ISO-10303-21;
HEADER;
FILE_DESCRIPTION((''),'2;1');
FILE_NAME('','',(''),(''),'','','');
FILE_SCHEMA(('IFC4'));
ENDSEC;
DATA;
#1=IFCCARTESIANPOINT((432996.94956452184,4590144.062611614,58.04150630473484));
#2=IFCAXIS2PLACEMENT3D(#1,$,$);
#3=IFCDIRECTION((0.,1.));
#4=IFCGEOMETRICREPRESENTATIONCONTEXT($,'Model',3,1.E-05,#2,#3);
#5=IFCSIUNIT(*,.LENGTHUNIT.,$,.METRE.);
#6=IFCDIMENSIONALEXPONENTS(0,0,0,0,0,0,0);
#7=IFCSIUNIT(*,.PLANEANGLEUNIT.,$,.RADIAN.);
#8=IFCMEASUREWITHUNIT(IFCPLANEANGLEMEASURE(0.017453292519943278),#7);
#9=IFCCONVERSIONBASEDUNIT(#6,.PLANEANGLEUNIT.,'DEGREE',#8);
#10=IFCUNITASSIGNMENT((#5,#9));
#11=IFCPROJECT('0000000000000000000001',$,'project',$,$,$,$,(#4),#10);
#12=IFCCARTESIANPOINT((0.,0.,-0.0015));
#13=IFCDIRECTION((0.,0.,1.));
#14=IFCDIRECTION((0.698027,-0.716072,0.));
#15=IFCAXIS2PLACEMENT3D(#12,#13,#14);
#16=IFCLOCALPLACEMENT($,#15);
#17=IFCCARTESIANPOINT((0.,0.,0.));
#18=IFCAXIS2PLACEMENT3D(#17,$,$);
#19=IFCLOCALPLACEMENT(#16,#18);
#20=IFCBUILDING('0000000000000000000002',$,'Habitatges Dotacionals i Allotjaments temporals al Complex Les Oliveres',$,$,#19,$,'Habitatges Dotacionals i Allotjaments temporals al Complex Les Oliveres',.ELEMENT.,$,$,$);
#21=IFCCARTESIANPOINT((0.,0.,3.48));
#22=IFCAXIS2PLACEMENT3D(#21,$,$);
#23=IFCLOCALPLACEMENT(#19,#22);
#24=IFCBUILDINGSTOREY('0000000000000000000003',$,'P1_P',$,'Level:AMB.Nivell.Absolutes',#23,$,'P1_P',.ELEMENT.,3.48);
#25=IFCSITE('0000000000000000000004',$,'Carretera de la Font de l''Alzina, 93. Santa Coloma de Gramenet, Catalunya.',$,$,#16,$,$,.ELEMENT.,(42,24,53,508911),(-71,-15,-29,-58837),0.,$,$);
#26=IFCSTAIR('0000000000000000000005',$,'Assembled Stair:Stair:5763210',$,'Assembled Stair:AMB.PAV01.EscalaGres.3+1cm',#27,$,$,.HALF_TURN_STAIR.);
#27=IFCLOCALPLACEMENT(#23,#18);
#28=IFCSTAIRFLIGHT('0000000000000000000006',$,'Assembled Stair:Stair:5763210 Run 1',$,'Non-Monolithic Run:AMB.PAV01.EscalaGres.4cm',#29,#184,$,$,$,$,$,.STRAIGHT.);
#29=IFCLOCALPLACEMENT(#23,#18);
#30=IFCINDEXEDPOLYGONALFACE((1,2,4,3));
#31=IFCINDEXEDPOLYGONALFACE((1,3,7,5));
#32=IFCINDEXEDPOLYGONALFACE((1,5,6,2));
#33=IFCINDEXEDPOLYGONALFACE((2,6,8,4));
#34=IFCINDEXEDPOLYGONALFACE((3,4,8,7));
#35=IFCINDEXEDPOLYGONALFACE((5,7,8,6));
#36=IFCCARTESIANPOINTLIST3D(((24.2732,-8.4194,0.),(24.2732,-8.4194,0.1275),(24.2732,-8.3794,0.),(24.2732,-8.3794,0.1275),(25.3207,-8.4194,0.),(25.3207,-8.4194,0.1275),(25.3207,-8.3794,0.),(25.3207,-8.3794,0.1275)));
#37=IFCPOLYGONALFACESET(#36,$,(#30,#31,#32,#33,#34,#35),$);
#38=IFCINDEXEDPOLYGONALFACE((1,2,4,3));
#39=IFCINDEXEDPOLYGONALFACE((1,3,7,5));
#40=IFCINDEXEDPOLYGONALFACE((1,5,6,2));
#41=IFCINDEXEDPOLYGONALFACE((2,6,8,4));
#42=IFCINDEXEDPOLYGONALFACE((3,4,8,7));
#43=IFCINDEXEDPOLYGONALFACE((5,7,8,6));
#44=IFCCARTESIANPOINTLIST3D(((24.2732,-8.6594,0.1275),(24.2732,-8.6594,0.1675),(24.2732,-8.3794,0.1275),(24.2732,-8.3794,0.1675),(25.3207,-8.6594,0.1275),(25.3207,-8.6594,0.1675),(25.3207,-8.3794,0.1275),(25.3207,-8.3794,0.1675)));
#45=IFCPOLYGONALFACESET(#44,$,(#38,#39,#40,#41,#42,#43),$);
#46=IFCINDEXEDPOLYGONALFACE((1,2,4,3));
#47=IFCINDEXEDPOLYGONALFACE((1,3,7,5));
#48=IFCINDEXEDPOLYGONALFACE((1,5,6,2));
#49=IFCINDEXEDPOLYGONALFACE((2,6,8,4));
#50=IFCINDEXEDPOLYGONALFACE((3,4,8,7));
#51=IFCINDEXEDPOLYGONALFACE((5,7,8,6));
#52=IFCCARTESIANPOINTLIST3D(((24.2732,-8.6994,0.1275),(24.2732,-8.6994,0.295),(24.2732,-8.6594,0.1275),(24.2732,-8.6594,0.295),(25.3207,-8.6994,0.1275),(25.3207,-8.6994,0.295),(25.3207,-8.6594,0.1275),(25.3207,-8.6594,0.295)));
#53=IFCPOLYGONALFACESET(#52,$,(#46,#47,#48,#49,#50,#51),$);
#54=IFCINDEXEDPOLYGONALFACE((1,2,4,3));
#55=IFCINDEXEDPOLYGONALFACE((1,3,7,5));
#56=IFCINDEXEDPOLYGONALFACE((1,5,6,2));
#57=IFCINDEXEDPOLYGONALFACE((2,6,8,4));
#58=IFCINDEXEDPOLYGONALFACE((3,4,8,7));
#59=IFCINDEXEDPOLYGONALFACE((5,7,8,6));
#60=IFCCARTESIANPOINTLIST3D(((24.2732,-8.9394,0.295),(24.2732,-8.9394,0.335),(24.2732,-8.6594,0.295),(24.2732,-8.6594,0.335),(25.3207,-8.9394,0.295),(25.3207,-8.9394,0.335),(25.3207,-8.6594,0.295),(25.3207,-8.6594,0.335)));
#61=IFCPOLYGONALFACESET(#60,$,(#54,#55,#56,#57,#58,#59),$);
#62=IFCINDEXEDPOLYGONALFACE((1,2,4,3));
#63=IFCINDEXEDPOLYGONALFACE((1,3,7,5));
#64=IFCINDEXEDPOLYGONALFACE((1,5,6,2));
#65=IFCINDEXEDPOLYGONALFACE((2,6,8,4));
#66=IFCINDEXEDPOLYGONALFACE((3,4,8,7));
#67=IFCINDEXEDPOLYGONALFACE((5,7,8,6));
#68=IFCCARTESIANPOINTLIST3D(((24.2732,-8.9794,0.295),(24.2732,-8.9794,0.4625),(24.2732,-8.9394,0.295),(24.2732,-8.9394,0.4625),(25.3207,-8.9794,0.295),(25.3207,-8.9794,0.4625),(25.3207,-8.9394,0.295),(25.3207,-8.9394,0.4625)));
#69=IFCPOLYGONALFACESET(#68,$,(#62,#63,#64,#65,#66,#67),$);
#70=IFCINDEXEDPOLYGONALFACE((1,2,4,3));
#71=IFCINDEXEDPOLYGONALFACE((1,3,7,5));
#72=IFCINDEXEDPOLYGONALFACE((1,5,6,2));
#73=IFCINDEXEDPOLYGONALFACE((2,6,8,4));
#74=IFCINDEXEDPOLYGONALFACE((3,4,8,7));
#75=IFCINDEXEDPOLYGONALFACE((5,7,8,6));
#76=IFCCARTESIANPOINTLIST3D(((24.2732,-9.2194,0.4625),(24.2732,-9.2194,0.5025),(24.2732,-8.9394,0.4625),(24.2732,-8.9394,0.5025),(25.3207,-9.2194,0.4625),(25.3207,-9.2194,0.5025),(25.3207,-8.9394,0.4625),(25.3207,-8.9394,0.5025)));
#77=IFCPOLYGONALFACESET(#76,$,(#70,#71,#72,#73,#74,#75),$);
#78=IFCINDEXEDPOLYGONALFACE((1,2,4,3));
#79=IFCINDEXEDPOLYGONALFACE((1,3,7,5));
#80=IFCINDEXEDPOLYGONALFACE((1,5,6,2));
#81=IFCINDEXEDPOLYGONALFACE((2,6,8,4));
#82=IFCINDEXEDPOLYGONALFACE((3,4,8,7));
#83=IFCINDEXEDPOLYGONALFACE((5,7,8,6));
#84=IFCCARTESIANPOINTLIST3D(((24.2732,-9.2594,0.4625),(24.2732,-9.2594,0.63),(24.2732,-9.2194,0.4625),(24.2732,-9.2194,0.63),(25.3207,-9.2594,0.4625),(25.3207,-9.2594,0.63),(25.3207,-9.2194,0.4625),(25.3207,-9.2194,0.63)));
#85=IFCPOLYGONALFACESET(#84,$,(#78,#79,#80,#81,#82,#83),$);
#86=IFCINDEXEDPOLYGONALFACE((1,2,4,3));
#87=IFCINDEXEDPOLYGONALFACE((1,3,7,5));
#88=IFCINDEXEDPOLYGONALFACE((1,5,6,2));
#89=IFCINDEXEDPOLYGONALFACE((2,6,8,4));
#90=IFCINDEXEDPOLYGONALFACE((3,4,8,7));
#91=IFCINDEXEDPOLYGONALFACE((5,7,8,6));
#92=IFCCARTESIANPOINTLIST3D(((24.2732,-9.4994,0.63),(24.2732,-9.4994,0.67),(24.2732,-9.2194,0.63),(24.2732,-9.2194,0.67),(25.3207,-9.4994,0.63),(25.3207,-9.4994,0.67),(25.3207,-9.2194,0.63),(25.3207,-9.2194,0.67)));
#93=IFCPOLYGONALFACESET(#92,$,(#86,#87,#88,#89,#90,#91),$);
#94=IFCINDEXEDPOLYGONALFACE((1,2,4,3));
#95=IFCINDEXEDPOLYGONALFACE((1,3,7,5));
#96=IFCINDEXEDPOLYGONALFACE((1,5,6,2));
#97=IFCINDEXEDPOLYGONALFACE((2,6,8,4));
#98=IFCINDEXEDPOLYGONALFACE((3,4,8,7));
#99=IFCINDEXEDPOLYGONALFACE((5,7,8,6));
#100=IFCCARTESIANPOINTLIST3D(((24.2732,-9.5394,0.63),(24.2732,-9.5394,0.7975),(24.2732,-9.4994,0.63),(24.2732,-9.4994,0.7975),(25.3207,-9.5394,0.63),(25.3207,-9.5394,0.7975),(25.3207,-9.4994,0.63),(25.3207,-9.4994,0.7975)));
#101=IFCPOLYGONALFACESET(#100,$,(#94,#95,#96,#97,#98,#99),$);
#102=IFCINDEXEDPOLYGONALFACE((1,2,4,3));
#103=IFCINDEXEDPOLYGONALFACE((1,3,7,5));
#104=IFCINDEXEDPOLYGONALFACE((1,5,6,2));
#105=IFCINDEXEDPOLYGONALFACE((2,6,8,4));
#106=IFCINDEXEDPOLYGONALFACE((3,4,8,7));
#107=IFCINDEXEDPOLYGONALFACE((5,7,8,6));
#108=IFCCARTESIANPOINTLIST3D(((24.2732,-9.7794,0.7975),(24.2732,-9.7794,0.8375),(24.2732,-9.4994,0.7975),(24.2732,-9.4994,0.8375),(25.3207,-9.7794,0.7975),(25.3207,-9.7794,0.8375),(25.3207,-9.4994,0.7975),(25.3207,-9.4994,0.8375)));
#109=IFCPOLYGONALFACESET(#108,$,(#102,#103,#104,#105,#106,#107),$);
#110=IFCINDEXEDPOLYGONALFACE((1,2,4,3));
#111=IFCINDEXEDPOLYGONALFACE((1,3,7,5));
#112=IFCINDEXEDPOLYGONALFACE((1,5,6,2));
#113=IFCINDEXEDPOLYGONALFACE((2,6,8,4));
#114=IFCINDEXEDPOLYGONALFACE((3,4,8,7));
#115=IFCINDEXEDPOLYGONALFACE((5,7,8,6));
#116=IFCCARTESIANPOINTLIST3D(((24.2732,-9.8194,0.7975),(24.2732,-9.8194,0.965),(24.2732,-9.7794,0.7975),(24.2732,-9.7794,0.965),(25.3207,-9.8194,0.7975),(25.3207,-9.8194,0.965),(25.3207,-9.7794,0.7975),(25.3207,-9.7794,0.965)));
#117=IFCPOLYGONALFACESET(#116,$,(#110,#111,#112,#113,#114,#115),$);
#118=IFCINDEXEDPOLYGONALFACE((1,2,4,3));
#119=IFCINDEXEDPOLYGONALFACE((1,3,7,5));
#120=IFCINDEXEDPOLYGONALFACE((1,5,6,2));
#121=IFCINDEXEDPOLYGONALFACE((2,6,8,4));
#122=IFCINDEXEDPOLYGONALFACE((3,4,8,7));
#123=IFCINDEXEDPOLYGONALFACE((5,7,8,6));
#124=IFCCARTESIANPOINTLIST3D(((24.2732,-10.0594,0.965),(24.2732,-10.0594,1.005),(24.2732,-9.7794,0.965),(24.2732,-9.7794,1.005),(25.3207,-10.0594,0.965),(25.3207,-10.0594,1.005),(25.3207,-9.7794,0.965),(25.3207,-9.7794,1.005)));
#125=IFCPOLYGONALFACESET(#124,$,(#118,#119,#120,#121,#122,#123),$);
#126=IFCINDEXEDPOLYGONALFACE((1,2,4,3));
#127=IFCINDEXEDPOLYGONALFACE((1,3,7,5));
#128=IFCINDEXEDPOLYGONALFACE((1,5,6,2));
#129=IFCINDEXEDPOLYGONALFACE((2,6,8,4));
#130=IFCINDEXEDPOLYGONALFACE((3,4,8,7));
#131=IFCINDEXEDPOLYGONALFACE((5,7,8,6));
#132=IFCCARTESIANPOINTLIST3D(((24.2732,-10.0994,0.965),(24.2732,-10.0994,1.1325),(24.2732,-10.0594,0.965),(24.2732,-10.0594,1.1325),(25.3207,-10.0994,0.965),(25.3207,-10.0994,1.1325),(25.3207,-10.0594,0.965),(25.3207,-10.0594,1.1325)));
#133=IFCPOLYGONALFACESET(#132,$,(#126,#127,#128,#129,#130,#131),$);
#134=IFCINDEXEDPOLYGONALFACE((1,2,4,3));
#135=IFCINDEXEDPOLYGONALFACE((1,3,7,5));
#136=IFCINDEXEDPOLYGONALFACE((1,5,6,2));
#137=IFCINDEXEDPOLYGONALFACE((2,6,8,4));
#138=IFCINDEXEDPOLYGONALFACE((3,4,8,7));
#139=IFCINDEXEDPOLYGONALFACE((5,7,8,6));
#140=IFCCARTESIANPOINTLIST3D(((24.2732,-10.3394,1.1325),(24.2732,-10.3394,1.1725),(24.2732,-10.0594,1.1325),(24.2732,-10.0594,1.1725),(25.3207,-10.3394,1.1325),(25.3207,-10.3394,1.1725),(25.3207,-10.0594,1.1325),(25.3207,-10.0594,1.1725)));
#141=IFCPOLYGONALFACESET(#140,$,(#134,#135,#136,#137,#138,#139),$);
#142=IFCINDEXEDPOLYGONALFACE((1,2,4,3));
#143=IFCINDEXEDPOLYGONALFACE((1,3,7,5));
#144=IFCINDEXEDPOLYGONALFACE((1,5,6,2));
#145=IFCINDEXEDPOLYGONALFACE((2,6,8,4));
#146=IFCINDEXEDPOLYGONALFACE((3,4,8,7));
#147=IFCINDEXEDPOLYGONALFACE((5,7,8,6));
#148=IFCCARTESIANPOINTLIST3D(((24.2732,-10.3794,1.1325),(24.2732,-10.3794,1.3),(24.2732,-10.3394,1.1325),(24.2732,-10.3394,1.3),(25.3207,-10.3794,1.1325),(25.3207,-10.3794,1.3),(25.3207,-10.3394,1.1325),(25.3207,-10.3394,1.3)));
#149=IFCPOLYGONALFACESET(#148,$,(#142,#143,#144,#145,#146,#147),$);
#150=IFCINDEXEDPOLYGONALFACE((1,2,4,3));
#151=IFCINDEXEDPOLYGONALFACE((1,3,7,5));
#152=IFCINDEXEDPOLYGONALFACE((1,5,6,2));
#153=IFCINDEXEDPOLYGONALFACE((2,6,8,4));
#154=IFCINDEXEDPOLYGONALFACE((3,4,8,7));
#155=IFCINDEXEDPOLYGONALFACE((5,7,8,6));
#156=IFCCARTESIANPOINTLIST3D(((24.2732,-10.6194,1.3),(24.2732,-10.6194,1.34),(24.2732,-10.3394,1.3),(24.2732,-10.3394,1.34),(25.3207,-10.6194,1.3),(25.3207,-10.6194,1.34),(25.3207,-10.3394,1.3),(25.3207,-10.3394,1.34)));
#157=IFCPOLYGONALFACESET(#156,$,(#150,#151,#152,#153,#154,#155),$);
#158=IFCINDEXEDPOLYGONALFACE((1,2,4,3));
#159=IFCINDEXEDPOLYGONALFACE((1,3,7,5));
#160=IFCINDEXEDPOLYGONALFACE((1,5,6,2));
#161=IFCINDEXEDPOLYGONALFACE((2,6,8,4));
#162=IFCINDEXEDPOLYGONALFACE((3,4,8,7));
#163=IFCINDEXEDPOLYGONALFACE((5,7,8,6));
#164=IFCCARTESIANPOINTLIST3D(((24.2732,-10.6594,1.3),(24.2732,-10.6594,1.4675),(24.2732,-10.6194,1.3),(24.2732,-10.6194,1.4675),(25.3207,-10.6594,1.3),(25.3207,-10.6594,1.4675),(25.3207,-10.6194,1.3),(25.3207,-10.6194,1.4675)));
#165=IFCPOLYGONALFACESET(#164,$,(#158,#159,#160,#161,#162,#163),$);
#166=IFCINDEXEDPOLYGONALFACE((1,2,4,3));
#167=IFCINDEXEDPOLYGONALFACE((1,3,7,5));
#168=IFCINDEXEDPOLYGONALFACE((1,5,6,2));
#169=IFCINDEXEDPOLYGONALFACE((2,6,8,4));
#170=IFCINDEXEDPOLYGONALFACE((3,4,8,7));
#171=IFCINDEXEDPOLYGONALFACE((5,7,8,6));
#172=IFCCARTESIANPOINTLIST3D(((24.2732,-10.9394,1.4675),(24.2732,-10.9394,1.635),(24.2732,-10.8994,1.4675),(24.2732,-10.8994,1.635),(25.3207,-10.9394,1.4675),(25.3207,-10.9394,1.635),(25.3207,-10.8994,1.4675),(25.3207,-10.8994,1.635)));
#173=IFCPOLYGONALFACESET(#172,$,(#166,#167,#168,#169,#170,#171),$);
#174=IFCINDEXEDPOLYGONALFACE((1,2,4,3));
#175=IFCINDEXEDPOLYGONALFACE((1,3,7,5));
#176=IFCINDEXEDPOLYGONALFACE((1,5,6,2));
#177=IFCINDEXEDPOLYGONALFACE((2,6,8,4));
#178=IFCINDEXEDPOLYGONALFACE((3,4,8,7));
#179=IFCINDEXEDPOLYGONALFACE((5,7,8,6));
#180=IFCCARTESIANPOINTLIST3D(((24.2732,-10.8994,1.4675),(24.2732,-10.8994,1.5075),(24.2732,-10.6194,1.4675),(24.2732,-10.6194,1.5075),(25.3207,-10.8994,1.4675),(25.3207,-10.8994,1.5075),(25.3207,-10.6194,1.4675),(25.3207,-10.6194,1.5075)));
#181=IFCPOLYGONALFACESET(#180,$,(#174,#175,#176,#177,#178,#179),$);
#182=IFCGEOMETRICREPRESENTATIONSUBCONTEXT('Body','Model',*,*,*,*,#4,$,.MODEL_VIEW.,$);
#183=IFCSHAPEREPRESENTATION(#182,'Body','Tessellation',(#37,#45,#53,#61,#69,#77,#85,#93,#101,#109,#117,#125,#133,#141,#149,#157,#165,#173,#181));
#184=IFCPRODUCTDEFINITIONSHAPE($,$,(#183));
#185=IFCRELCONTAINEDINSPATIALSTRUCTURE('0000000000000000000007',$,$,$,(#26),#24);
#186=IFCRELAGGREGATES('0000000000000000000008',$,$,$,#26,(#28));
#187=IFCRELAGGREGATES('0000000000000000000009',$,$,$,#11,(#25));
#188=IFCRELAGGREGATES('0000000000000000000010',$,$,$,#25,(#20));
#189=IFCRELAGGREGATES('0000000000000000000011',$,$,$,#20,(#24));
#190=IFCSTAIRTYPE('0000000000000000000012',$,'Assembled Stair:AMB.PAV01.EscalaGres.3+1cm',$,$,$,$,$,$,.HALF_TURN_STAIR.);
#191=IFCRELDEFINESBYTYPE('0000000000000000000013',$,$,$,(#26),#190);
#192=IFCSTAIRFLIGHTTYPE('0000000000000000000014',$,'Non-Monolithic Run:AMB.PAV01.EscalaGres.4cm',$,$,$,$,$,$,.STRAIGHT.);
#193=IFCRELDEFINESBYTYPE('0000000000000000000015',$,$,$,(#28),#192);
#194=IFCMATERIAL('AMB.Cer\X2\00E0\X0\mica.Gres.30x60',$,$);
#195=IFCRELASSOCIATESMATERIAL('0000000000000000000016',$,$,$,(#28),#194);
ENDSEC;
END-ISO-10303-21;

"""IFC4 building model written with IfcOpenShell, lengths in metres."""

from ifc_helpers import new_model, entity, si_unit, converted_unit, direction, frame, origin, place, context, subcontext, project, spatial, indexed_curve, outline, extrude, material, type_object, element, aggregate, save


model = new_model("IFC4")

# Units and contexts
model_context = context("Model", 3, precision=1e-05, world=frame((432996.94956452184, 4590144.062611614, 58.04150630473484)), true_north=direction((0.0, 1.0)))
body_context = subcontext(model_context, "Body", "Model", "MODEL_VIEW")
ifc_project = project(units=[si_unit("LENGTHUNIT", "METRE"), converted_unit("PLANEANGLEUNIT", "DEGREE", entity("IfcPlaneAngleMeasure", 0.017453292519943278), si_unit("PLANEANGLEUNIT", "RADIAN"), dimensions=[0, 0, 0, 0, 0, 0, 0])], contexts=[model_context])

# Site, building, storey
site_placement = place(None, frame((0.0, 0.0, -0.0015), z_axis=(0.0, 0.0, 1.0), x_axis=(0.698027, -0.716072, 0.0)))
site = spatial("IfcSite", under=ifc_project, at=site_placement, Name="Carretera de la Font de l'Alzina, 93. Santa Coloma de Gramenet, Catalunya.", CompositionType="ELEMENT", RefLatitude=(42, 24, 53, 508911), RefLongitude=(-71, -15, -29, -58837), RefElevation=0.0)
building_placement = place(site_placement, origin())
building = spatial("IfcBuilding", under=site, at=building_placement, Name="Habitatges Dotacionals i Allotjaments temporals al Complex Les Oliveres", LongName="Habitatges Dotacionals i Allotjaments temporals al Complex Les Oliveres", CompositionType="ELEMENT")
storey_placement = place(building_placement, frame((0.0, 0.0, 3.48)))
storey = spatial("IfcBuildingStorey", under=building, at=storey_placement, Name="P1_P", ObjectType="Level:AMB.Nivell.Absolutes", LongName="P1_P", CompositionType="ELEMENT", Elevation=3.48)

# Stair
stair_type_1 = type_object("IfcStairType", Name="Assembled Stair:AMB.PAV01.EscalaGres.3+1cm", PredefinedType="HALF_TURN_STAIR")
ifc_material_1 = material(Name="AMB.Ceràmica.Gres.30x60")
stair_1_placement = place(storey_placement, origin())
stair_1 = element("IfcStair", 1, at=stair_1_placement, inside=storey, type_object=stair_type_1, Name="Assembled Stair:Stair:5763210", ObjectType="Assembled Stair:AMB.PAV01.EscalaGres.3+1cm", PredefinedType="HALF_TURN_STAIR")

# Shared definitions
stair_flight_type = type_object("IfcStairFlightType", Name="Non-Monolithic Run:AMB.PAV01.EscalaGres.4cm", PredefinedType="STRAIGHT")

# Stair flight
stair_flight_1_placement = place(stair_1_placement, origin())
stair_flight_1 = element("IfcStairFlight", 2, at=stair_flight_1_placement, type_object=stair_flight_type, material=ifc_material_1, Name="Assembled Stair:Stair:5763210 Run 1", ObjectType="Non-Monolithic Run:AMB.PAV01.EscalaGres.4cm", PredefinedType="STRAIGHT", context=body_context, shape_type="SweptSolid", body=[
    extrude(outline(indexed_curve([(-0.5238, -0.02), (0.5238, -0.02), (0.5238, 0.02), (-0.5238, 0.02), (-0.5238, -0.02)], self_intersect=False)), frame((24.797, -8.3994, 0.0)), (0.0, 0.0, 1.0), 0.1275),
    extrude(outline(indexed_curve([(-0.14, -0.5238), (0.14, -0.5238), (0.14, 0.5238), (-0.14, 0.5238), (-0.14, -0.5238)], self_intersect=False)), frame((24.797, -8.5194, 0.1275), z_axis=(0.0, 0.0, 1.0), x_axis=(0.0, 1.0, 0.0)), (0.0, 0.0, 1.0), 0.04),
    extrude(outline(indexed_curve([(-0.5238, -0.02), (0.5238, -0.02), (0.5238, 0.02), (-0.5238, 0.02), (-0.5238, -0.02)], self_intersect=False)), frame((24.797, -8.6794, 0.1275)), (0.0, 0.0, 1.0), 0.1675),
    extrude(outline(indexed_curve([(-0.14, -0.5238), (0.14, -0.5238), (0.14, 0.5238), (-0.14, 0.5238), (-0.14, -0.5238)], self_intersect=False)), frame((24.797, -8.7994, 0.295), z_axis=(0.0, 0.0, 1.0), x_axis=(0.0, 1.0, 0.0)), (0.0, 0.0, 1.0), 0.04),
    extrude(outline(indexed_curve([(-0.5238, -0.02), (0.5238, -0.02), (0.5238, 0.02), (-0.5238, 0.02), (-0.5238, -0.02)], self_intersect=False)), frame((24.797, -8.9594, 0.295)), (0.0, 0.0, 1.0), 0.1675),
    extrude(outline(indexed_curve([(-0.14, -0.5238), (0.14, -0.5238), (0.14, 0.5238), (-0.14, 0.5238), (-0.14, -0.5238)], self_intersect=False)), frame((24.797, -9.0794, 0.4625), z_axis=(0.0, 0.0, 1.0), x_axis=(0.0, 1.0, 0.0)), (0.0, 0.0, 1.0), 0.04),
    extrude(outline(indexed_curve([(-0.5238, -0.02), (0.5238, -0.02), (0.5238, 0.02), (-0.5238, 0.02), (-0.5238, -0.02)], self_intersect=False)), frame((24.797, -9.2394, 0.4625)), (0.0, 0.0, 1.0), 0.1675),
    extrude(outline(indexed_curve([(-0.14, -0.5238), (0.14, -0.5238), (0.14, 0.5238), (-0.14, 0.5238), (-0.14, -0.5238)], self_intersect=False)), frame((24.797, -9.3594, 0.63), z_axis=(0.0, 0.0, 1.0), x_axis=(0.0, 1.0, 0.0)), (0.0, 0.0, 1.0), 0.04),
    extrude(outline(indexed_curve([(-0.5238, -0.02), (0.5238, -0.02), (0.5238, 0.02), (-0.5238, 0.02), (-0.5238, -0.02)], self_intersect=False)), frame((24.797, -9.5194, 0.63)), (0.0, 0.0, 1.0), 0.1675),
    extrude(outline(indexed_curve([(-0.14, -0.5238), (0.14, -0.5238), (0.14, 0.5238), (-0.14, 0.5238), (-0.14, -0.5238)], self_intersect=False)), frame((24.797, -9.6394, 0.7975), z_axis=(0.0, 0.0, 1.0), x_axis=(0.0, 1.0, 0.0)), (0.0, 0.0, 1.0), 0.04),
    extrude(outline(indexed_curve([(-0.5238, -0.02), (0.5238, -0.02), (0.5238, 0.02), (-0.5238, 0.02), (-0.5238, -0.02)], self_intersect=False)), frame((24.797, -9.7994, 0.7975)), (0.0, 0.0, 1.0), 0.1675),
    extrude(outline(indexed_curve([(-0.14, -0.5238), (0.14, -0.5238), (0.14, 0.5238), (-0.14, 0.5238), (-0.14, -0.5238)], self_intersect=False)), frame((24.797, -9.9194, 0.965), z_axis=(0.0, 0.0, 1.0), x_axis=(0.0, 1.0, 0.0)), (0.0, 0.0, 1.0), 0.04),
    extrude(outline(indexed_curve([(-0.5238, -0.02), (0.5238, -0.02), (0.5238, 0.02), (-0.5238, 0.02), (-0.5238, -0.02)], self_intersect=False)), frame((24.797, -10.0794, 0.965)), (0.0, 0.0, 1.0), 0.1675),
    extrude(outline(indexed_curve([(-0.14, -0.5238), (0.14, -0.5238), (0.14, 0.5238), (-0.14, 0.5238), (-0.14, -0.5238)], self_intersect=False)), frame((24.797, -10.1994, 1.1325), z_axis=(0.0, 0.0, 1.0), x_axis=(0.0, 1.0, 0.0)), (0.0, 0.0, 1.0), 0.04),
    extrude(outline(indexed_curve([(-0.5238, -0.02), (0.5238, -0.02), (0.5238, 0.02), (-0.5238, 0.02), (-0.5238, -0.02)], self_intersect=False)), frame((24.797, -10.3594, 1.1325)), (0.0, 0.0, 1.0), 0.1675),
    extrude(outline(indexed_curve([(-0.14, -0.5238), (0.14, -0.5238), (0.14, 0.5238), (-0.14, 0.5238), (-0.14, -0.5238)], self_intersect=False)), frame((24.797, -10.4794, 1.3), z_axis=(0.0, 0.0, 1.0), x_axis=(0.0, 1.0, 0.0)), (0.0, 0.0, 1.0), 0.04),
    extrude(outline(indexed_curve([(-0.5238, -0.02), (0.5238, -0.02), (0.5238, 0.02), (-0.5238, 0.02), (-0.5238, -0.02)], self_intersect=False)), frame((24.797, -10.6394, 1.3)), (0.0, 0.0, 1.0), 0.1675),
    extrude(outline(indexed_curve([(-0.5238, -0.02), (0.5238, -0.02), (0.5238, 0.02), (-0.5238, 0.02), (-0.5238, -0.02)], self_intersect=False)), frame((24.797, -10.9194, 1.4675)), (0.0, 0.0, 1.0), 0.1675),
    extrude(outline(indexed_curve([(-0.14, -0.5238), (0.14, -0.5238), (0.14, 0.5238), (-0.14, 0.5238), (-0.14, -0.5238)], self_intersect=False)), frame((24.797, -10.7594, 1.4675), z_axis=(0.0, 0.0, 1.0), x_axis=(0.0, 1.0, 0.0)), (0.0, 0.0, 1.0), 0.04),
])
aggregate(stair_1, [stair_flight_1])

save(model, "model.ifc")
